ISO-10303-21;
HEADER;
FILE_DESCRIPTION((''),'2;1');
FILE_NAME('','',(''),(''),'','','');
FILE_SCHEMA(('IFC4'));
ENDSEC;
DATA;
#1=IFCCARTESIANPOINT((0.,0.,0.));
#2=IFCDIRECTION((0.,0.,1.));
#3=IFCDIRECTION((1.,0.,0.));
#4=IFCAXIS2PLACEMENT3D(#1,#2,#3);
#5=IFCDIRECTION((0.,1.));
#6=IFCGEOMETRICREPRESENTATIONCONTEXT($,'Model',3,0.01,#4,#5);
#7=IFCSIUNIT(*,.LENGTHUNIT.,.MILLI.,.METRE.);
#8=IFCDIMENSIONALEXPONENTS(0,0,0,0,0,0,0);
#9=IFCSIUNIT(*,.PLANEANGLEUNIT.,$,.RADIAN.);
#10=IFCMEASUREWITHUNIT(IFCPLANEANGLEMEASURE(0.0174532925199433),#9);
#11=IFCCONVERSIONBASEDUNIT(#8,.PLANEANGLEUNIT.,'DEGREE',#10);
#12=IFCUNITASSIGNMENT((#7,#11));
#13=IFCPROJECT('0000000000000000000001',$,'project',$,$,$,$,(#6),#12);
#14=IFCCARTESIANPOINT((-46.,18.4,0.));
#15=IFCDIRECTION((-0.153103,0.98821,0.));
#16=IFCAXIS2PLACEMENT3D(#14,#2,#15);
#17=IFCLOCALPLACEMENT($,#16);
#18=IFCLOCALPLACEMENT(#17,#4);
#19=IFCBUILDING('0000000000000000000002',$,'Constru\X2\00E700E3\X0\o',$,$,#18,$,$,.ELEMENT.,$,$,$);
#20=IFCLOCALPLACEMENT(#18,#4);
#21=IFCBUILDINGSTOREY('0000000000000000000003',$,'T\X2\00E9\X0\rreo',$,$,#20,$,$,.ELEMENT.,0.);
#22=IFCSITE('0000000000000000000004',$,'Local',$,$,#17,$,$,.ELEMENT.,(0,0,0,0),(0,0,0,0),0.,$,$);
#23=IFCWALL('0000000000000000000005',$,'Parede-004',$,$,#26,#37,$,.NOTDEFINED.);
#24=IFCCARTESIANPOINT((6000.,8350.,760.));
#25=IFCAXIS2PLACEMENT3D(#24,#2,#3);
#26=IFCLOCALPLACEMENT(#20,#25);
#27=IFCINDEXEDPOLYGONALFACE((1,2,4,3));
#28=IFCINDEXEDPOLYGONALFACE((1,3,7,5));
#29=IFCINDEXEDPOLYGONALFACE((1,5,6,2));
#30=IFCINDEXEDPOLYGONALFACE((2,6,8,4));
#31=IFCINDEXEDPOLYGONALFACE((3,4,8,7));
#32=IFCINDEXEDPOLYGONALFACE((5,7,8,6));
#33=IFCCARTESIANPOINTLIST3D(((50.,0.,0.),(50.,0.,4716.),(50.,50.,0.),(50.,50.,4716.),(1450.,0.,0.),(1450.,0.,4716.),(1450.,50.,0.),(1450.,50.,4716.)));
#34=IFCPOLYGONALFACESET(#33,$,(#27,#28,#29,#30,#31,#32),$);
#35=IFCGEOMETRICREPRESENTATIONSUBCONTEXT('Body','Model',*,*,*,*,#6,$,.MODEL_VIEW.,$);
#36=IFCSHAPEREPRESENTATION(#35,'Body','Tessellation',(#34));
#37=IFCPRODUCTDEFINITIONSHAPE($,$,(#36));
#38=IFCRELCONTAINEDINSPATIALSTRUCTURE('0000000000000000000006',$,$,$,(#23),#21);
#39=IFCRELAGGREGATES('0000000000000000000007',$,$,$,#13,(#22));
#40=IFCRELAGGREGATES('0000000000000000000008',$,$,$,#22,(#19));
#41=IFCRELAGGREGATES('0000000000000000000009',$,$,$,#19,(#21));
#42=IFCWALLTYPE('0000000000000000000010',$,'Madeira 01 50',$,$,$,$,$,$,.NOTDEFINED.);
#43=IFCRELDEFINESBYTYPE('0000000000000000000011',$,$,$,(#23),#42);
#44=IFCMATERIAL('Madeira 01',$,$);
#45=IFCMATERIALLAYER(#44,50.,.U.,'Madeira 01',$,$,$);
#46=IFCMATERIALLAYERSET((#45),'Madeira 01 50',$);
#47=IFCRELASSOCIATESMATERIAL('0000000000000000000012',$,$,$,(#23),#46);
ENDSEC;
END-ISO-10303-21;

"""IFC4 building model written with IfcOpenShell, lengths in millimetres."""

from ifc_helpers import new_model, entity, si_unit, converted_unit, direction, frame, origin_with_axes, place, context, subcontext, project, spatial, line, indexed_curve, outline, extrude, material, layer, layer_set, layer_usage, type_object, element, save


model = new_model("IFC4")

# Units and contexts
model_context = context("Model", 3, precision=0.01, world=origin_with_axes(), true_north=direction((0.0, 1.0)))
body_context = subcontext(model_context, "Body", "Model", "MODEL_VIEW")
ifc_project = project(units=[si_unit("LENGTHUNIT", "METRE", prefix="MILLI"), converted_unit("PLANEANGLEUNIT", "DEGREE", entity("IfcPlaneAngleMeasure", 0.0174532925199433), si_unit("PLANEANGLEUNIT", "RADIAN"), dimensions=[0, 0, 0, 0, 0, 0, 0])], contexts=[model_context])

# Site, building, storey
site_placement = place(None, frame((-46.0, 18.4, 0.0), z_axis=(0.0, 0.0, 1.0), x_axis=(-0.153103, 0.98821, 0.0)))
site = spatial("IfcSite", under=ifc_project, at=site_placement, Name="Local", CompositionType="ELEMENT", RefLatitude=(0, 0, 0, 0), RefLongitude=(0, 0, 0, 0), RefElevation=0.0)
building_placement = place(site_placement, origin_with_axes())
building = spatial("IfcBuilding", under=site, at=building_placement, Name="Construção", CompositionType="ELEMENT")
storey_placement = place(building_placement, origin_with_axes())
storey = spatial("IfcBuildingStorey", under=building, at=storey_placement, Name="Térreo", CompositionType="ELEMENT", Elevation=0.0)

# Wall
ifc_material_1 = material(Name="Madeira 01")
ifc_layer_1 = layer(ifc_material_1, 50.0, ventilated="UNKNOWN", Name="Madeira 01")
ifc_layer_set_1 = layer_set([ifc_layer_1], Name="Madeira 01 50")
ifc_layer_usage_1 = layer_usage(ifc_layer_set_1, "AXIS2", "NEGATIVE", 50.0)
wall_type_1 = type_object("IfcWallType", Name="Madeira 01 50", PredefinedType="NOTDEFINED")
wall_1_placement = place(storey_placement, frame((6000.0, 8350.0, 760.0), z_axis=(0.0, 0.0, 1.0), x_axis=(1.0, 0.0, 0.0)))
element("IfcWall", 1, at=wall_1_placement, inside=storey, type_object=wall_type_1, material=ifc_layer_usage_1, Name="Parede-004", PredefinedType="NOTDEFINED", context=body_context, shape_type="SweptSolid", body=[
    extrude(outline(indexed_curve([(50.0, 0.0), (1450.0, 0.0), (1450.0, 50.0), (50.0, 50.0)], segments=[line(1, 2, 3, 4, 1)])), origin_with_axes(), (0.0, 0.0, 1.0), 4716.0),
])

save(model, "model.ifc")
